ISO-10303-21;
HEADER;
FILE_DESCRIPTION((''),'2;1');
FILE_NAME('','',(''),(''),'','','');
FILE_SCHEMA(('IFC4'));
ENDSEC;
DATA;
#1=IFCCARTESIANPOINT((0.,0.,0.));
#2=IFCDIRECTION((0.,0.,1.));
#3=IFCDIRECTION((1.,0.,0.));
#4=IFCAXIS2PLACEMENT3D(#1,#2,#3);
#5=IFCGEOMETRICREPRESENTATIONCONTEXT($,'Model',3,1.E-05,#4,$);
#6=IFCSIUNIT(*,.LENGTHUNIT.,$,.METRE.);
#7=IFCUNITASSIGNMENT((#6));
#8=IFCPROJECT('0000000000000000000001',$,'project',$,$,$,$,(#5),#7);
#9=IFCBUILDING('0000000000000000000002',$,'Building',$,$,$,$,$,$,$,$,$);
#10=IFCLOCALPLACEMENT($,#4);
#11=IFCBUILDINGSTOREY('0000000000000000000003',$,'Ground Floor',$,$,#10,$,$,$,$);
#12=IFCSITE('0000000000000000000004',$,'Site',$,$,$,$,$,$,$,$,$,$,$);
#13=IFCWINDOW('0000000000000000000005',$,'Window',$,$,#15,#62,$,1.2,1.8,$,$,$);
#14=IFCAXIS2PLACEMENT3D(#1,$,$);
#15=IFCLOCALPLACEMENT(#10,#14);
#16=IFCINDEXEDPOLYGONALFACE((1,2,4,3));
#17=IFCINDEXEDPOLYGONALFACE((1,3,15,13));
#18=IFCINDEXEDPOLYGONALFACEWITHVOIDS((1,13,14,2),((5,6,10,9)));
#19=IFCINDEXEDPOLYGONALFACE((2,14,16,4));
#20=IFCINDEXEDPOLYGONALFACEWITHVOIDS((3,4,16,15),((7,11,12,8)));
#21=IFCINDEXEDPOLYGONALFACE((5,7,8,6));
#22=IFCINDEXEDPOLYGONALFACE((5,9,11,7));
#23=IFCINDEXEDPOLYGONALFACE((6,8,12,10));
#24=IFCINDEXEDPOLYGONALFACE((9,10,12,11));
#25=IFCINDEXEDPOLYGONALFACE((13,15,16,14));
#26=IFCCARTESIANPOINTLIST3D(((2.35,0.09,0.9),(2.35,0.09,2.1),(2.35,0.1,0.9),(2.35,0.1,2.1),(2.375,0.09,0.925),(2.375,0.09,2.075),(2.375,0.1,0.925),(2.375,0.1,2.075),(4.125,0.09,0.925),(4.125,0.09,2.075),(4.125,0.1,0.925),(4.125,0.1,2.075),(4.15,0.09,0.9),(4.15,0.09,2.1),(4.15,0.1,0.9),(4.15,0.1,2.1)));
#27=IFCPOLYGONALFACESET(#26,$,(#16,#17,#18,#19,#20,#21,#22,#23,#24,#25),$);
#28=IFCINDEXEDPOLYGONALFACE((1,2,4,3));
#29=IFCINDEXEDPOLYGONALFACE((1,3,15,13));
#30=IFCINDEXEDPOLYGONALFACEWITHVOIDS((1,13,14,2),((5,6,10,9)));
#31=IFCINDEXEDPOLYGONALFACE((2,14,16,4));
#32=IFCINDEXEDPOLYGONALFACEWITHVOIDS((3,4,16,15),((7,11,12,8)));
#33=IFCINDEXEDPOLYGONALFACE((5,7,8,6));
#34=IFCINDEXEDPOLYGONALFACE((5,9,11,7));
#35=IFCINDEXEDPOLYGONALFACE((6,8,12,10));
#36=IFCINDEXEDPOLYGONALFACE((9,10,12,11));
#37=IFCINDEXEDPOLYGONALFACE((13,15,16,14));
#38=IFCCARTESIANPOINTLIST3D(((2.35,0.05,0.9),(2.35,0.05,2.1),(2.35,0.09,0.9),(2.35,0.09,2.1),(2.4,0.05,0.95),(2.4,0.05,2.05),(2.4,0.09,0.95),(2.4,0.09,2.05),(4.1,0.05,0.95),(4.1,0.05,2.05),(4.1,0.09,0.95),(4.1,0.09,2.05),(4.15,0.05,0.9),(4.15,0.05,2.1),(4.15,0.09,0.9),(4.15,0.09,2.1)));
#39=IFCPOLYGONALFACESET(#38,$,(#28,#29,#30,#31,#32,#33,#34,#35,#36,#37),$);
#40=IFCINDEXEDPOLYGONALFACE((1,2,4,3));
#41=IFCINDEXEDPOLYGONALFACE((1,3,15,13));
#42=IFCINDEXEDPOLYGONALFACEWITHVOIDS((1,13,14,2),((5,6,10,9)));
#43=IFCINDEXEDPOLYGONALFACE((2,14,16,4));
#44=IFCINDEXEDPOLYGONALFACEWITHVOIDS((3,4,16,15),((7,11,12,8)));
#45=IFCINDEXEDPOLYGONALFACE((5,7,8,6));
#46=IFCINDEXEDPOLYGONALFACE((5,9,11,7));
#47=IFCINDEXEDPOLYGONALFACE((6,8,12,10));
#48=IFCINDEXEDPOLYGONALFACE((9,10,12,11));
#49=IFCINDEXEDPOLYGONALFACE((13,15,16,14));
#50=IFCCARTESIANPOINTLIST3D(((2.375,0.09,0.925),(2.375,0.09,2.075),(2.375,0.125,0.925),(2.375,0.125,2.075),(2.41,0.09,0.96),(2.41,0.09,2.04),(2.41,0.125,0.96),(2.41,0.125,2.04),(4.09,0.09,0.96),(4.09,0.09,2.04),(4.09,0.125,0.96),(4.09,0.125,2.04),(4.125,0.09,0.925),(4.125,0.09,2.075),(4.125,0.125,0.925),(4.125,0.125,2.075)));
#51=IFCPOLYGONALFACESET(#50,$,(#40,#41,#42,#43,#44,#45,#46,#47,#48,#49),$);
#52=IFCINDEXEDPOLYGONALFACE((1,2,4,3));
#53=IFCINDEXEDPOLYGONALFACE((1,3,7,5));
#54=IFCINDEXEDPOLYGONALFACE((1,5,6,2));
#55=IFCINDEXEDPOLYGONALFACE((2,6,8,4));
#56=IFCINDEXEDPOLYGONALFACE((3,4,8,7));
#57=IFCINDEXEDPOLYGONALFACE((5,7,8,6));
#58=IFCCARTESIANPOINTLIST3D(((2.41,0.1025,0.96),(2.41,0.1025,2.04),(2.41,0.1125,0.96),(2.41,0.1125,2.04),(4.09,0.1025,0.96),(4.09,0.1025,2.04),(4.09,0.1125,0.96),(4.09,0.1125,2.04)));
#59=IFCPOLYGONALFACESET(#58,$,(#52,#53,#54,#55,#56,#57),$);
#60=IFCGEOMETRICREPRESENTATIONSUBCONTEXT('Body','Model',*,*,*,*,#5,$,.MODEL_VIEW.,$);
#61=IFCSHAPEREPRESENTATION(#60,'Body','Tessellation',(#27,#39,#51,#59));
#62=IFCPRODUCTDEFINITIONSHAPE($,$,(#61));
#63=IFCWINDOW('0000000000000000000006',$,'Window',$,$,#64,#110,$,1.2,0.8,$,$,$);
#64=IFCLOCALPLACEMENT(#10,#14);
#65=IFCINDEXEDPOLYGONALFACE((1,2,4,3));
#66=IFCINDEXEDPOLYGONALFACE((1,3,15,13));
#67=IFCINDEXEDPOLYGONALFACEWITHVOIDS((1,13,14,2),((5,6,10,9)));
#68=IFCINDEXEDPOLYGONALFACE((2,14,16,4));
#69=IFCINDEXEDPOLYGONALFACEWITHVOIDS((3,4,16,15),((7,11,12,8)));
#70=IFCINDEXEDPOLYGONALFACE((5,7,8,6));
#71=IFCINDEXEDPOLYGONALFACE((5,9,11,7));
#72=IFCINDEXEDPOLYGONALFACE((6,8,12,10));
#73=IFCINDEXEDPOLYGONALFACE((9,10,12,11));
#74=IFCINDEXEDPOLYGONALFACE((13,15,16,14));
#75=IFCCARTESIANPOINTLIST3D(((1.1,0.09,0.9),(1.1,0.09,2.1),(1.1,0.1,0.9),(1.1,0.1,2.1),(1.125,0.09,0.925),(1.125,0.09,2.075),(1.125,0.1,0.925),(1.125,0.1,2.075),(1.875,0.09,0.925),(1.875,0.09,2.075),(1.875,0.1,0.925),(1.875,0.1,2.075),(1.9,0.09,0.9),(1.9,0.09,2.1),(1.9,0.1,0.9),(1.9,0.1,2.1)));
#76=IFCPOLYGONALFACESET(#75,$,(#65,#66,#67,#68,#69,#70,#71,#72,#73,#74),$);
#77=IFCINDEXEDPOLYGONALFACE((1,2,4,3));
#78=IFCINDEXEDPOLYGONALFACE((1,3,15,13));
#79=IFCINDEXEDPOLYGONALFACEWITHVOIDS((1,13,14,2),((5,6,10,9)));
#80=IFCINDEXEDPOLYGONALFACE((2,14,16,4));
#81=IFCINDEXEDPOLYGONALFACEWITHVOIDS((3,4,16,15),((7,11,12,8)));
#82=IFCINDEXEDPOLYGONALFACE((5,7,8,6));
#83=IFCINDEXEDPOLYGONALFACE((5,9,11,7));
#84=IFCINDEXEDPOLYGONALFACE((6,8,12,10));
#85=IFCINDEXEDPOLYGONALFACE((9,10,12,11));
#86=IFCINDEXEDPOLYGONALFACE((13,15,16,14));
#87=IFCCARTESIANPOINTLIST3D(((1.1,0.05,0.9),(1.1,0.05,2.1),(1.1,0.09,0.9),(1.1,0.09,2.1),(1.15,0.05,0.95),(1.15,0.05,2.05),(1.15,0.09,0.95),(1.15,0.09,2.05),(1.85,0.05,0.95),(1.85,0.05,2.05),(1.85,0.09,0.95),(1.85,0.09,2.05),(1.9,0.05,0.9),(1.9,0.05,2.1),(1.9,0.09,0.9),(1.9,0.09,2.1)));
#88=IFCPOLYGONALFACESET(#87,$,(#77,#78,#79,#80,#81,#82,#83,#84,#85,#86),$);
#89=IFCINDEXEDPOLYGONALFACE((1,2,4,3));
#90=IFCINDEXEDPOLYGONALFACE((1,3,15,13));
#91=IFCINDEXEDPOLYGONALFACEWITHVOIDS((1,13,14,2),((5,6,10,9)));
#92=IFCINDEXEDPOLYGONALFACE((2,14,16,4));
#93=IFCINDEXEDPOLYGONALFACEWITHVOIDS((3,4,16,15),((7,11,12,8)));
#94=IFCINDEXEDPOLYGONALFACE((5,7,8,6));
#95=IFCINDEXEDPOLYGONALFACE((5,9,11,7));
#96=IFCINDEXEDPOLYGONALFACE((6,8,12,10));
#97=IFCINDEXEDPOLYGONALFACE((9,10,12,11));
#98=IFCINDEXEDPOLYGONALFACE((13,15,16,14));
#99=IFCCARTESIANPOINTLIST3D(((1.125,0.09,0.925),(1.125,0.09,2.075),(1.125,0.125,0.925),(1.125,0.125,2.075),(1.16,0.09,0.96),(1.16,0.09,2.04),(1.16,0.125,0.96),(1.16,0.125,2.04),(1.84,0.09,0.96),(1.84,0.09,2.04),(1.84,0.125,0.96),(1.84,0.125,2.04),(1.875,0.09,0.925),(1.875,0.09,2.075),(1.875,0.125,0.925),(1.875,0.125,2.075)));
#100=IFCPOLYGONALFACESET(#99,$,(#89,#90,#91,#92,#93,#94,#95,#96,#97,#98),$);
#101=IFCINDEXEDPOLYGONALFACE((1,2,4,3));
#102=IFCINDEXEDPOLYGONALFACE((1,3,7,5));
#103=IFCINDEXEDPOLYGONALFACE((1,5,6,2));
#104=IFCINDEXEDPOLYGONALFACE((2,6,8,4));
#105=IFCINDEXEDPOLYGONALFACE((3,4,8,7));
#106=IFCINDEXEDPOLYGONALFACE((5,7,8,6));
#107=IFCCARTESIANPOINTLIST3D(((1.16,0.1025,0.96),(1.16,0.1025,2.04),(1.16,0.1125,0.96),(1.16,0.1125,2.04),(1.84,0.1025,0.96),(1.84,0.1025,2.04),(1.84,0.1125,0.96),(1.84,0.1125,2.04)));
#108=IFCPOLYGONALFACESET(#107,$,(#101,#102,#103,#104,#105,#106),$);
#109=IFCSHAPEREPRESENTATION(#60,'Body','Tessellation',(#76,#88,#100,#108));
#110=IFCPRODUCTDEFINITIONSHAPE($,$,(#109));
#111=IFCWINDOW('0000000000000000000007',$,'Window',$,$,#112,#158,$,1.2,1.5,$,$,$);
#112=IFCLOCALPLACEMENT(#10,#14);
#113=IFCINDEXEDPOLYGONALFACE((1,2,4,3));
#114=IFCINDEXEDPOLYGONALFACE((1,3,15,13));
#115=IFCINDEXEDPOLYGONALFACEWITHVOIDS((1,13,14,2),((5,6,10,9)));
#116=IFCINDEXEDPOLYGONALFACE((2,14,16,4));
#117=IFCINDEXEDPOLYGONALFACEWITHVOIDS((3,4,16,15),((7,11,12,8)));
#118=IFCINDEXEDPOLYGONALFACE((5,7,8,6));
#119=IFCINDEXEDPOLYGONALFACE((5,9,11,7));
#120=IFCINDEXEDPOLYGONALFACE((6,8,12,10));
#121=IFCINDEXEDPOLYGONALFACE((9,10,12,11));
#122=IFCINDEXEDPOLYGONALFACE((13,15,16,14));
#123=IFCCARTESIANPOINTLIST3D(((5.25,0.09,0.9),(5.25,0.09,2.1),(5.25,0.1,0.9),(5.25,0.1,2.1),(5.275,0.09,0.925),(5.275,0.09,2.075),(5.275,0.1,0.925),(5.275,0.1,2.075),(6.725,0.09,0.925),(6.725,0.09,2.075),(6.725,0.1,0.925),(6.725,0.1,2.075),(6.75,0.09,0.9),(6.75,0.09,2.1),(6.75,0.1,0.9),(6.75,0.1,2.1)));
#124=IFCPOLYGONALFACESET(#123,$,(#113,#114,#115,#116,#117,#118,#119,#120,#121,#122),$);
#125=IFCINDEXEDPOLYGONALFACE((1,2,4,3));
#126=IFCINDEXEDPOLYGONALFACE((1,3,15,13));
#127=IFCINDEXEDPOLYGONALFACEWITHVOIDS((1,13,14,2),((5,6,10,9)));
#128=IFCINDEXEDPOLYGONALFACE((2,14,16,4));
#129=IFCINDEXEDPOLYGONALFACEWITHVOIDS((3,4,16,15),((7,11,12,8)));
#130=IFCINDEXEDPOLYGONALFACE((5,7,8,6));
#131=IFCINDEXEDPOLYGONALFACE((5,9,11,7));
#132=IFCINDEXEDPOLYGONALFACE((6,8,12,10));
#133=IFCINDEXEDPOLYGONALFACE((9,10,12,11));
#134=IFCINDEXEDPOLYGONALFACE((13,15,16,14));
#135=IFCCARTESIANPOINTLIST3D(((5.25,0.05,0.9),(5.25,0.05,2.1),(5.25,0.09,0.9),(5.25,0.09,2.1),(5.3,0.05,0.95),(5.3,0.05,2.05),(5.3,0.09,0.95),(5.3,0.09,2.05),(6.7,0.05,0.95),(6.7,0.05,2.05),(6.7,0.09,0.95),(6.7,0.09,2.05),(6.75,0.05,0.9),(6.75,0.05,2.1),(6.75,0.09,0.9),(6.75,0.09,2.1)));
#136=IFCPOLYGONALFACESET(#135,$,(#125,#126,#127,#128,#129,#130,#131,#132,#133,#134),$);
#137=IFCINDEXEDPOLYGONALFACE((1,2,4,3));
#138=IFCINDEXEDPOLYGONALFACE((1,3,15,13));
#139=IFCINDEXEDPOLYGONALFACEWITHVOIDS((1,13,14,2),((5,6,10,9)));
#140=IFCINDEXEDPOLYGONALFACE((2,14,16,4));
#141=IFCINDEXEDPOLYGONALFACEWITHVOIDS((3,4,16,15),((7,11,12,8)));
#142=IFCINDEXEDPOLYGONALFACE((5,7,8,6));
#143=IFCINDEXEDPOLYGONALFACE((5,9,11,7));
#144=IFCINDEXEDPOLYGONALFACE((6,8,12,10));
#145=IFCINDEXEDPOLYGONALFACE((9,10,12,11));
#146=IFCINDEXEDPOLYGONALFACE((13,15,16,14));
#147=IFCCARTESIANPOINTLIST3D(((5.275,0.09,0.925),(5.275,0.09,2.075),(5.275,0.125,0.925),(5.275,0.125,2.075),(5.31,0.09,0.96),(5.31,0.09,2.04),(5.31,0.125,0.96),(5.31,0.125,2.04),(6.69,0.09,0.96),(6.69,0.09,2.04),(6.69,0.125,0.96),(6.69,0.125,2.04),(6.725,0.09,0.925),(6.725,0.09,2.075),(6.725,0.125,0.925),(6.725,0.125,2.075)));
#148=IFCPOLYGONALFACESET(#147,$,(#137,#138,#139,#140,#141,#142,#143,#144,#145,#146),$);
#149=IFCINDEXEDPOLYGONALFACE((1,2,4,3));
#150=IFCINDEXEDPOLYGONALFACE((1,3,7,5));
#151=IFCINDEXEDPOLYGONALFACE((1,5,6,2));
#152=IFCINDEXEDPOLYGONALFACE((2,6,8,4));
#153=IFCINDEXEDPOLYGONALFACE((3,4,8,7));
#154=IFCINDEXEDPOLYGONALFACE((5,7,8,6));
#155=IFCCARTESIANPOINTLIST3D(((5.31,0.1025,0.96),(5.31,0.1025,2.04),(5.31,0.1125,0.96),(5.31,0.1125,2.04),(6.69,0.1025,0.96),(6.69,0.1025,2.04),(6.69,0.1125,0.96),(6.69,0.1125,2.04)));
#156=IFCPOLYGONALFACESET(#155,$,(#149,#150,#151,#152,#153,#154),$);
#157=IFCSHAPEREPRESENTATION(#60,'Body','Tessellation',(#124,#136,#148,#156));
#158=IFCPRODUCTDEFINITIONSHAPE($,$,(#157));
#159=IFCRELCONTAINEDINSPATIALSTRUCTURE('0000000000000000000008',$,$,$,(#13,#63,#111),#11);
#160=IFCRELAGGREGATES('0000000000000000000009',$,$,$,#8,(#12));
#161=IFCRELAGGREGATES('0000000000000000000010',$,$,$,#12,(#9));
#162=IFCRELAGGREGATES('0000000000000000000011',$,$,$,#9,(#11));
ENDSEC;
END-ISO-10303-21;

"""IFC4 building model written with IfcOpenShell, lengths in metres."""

from ifc_helpers import new_model, si_unit, frame, origin_with_axes, place, context, subcontext, project, spatial, line, indexed_curve, outline, extrude, element, save


model = new_model("IFC4")

# Units and contexts
model_context = context("Model", 3, precision=1e-05, world=origin_with_axes())
body_context = subcontext(model_context, "Body", "Model", "MODEL_VIEW")
ifc_project = project(units=[si_unit("LENGTHUNIT", "METRE")], contexts=[model_context])

# Site, building, storey
site = spatial("IfcSite", under=ifc_project, Name="Site")
building = spatial("IfcBuilding", under=site, Name="Building")
storey_placement = place(None, origin_with_axes())
storey = spatial("IfcBuildingStorey", under=building, at=storey_placement, Name="Ground Floor")

# Windows
window_1_placement = place(storey_placement, frame((2.35, 0.0, 0.9), z_axis=(0.0, 0.0, 1.0), x_axis=(1.0, 0.0, 0.0)))
element("IfcWindow", 1, at=window_1_placement, inside=storey, Name="Window", OverallHeight=1.2, OverallWidth=1.8, context=body_context, shape_type="SweptSolid", body=[
    extrude(outline(indexed_curve([(0.0, 0.0), (1.8, 0.0), (1.8, 1.2), (0.0, 1.2)], segments=[line(1, 2, 3, 4, 1)]), holes=[indexed_curve([(0.025, 0.025), (1.775, 0.025), (1.775, 1.175), (0.025, 1.175)], segments=[line(1, 2, 3, 4, 1)])]), frame((0.0, 0.09, 0.0), z_axis=(0.0, -1.0, 0.0), x_axis=(1.0, 0.0, 0.0)), (0.0, 0.0, -1.0), 0.01),
    extrude(outline(indexed_curve([(0.0, 0.0), (1.8, 0.0), (1.8, 1.2), (0.0, 1.2)], segments=[line(1, 2, 3, 4, 1)]), holes=[indexed_curve([(0.05, 0.05), (1.75, 0.05), (1.75, 1.15), (0.05, 1.15)], segments=[line(1, 2, 3, 4, 1)])]), frame((0.0, 0.05, 0.0), z_axis=(0.0, -1.0, 0.0), x_axis=(1.0, 0.0, 0.0)), (0.0, 0.0, -1.0), 0.04),
    extrude(outline(indexed_curve([(0.0, 0.0), (1.75, 0.0), (1.75, 1.15), (0.0, 1.15)], segments=[line(1, 2, 3, 4, 1)]), holes=[indexed_curve([(0.035, 0.035), (1.715, 0.035), (1.715, 1.115), (0.035, 1.115)], segments=[line(1, 2, 3, 4, 1)])]), frame((0.025, 0.09, 0.025), z_axis=(0.0, -1.0, 0.0), x_axis=(1.0, 0.0, 0.0)), (0.0, 0.0, -1.0), 0.035),
    extrude(outline(indexed_curve([(0.035, 0.035), (1.715, 0.035), (1.715, 1.115), (0.035, 1.115)], segments=[line(1, 2, 3, 4, 1)])), frame((0.025, 0.1025, 0.025), z_axis=(0.0, -1.0, 0.0), x_axis=(1.0, 0.0, 0.0)), (0.0, 0.0, -1.0), 0.01),
])
window_2_placement = place(storey_placement, frame((1.1, 0.0, 0.9), z_axis=(0.0, 0.0, 1.0), x_axis=(1.0, 0.0, 0.0)))
element("IfcWindow", 2, at=window_2_placement, inside=storey, Name="Window", OverallHeight=1.2, OverallWidth=0.8, context=body_context, shape_type="SweptSolid", body=[
    extrude(outline(indexed_curve([(0.0, 0.0), (0.8, 0.0), (0.8, 1.2), (0.0, 1.2)], segments=[line(1, 2, 3, 4, 1)]), holes=[indexed_curve([(0.025, 0.025), (0.775, 0.025), (0.775, 1.175), (0.025, 1.175)], segments=[line(1, 2, 3, 4, 1)])]), frame((0.0, 0.09, 0.0), z_axis=(0.0, -1.0, 0.0), x_axis=(1.0, 0.0, 0.0)), (0.0, 0.0, -1.0), 0.01),
    extrude(outline(indexed_curve([(0.0, 0.0), (0.8, 0.0), (0.8, 1.2), (0.0, 1.2)], segments=[line(1, 2, 3, 4, 1)]), holes=[indexed_curve([(0.05, 0.05), (0.75, 0.05), (0.75, 1.15), (0.05, 1.15)], segments=[line(1, 2, 3, 4, 1)])]), frame((0.0, 0.05, 0.0), z_axis=(0.0, -1.0, 0.0), x_axis=(1.0, 0.0, 0.0)), (0.0, 0.0, -1.0), 0.04),
    extrude(outline(indexed_curve([(0.0, 0.0), (0.75, 0.0), (0.75, 1.15), (0.0, 1.15)], segments=[line(1, 2, 3, 4, 1)]), holes=[indexed_curve([(0.035, 0.035), (0.715, 0.035), (0.715, 1.115), (0.035, 1.115)], segments=[line(1, 2, 3, 4, 1)])]), frame((0.025, 0.09, 0.025), z_axis=(0.0, -1.0, 0.0), x_axis=(1.0, 0.0, 0.0)), (0.0, 0.0, -1.0), 0.035),
    extrude(outline(indexed_curve([(0.035, 0.035), (0.715, 0.035), (0.715, 1.115), (0.035, 1.115)], segments=[line(1, 2, 3, 4, 1)])), frame((0.025, 0.1025, 0.025), z_axis=(0.0, -1.0, 0.0), x_axis=(1.0, 0.0, 0.0)), (0.0, 0.0, -1.0), 0.01),
])
window_3_placement = place(storey_placement, frame((5.25, 0.0, 0.9), z_axis=(0.0, 0.0, 1.0), x_axis=(1.0, 0.0, 0.0)))
element("IfcWindow", 3, at=window_3_placement, inside=storey, Name="Window", OverallHeight=1.2, OverallWidth=1.5, context=body_context, shape_type="SweptSolid", body=[
    extrude(outline(indexed_curve([(0.0, 0.0), (1.5, 0.0), (1.5, 1.2), (0.0, 1.2)], segments=[line(1, 2, 3, 4, 1)]), holes=[indexed_curve([(0.025, 0.025), (1.475, 0.025), (1.475, 1.175), (0.025, 1.175)], segments=[line(1, 2, 3, 4, 1)])]), frame((0.0, 0.09, 0.0), z_axis=(0.0, -1.0, 0.0), x_axis=(1.0, 0.0, 0.0)), (0.0, 0.0, -1.0), 0.01),
    extrude(outline(indexed_curve([(0.0, 0.0), (1.5, 0.0), (1.5, 1.2), (0.0, 1.2)], segments=[line(1, 2, 3, 4, 1)]), holes=[indexed_curve([(0.05, 0.05), (1.45, 0.05), (1.45, 1.15), (0.05, 1.15)], segments=[line(1, 2, 3, 4, 1)])]), frame((0.0, 0.05, 0.0), z_axis=(0.0, -1.0, 0.0), x_axis=(1.0, 0.0, 0.0)), (0.0, 0.0, -1.0), 0.04),
    extrude(outline(indexed_curve([(0.0, 0.0), (1.45, 0.0), (1.45, 1.15), (0.0, 1.15)], segments=[line(1, 2, 3, 4, 1)]), holes=[indexed_curve([(0.035, 0.035), (1.415, 0.035), (1.415, 1.115), (0.035, 1.115)], segments=[line(1, 2, 3, 4, 1)])]), frame((0.025, 0.09, 0.025), z_axis=(0.0, -1.0, 0.0), x_axis=(1.0, 0.0, 0.0)), (0.0, 0.0, -1.0), 0.035),
    extrude(outline(indexed_curve([(0.035, 0.035), (1.415, 0.035), (1.415, 1.115), (0.035, 1.115)], segments=[line(1, 2, 3, 4, 1)])), frame((0.025, 0.1025, 0.025), z_axis=(0.0, -1.0, 0.0), x_axis=(1.0, 0.0, 0.0)), (0.0, 0.0, -1.0), 0.01),
])

save(model, "model.ifc")
